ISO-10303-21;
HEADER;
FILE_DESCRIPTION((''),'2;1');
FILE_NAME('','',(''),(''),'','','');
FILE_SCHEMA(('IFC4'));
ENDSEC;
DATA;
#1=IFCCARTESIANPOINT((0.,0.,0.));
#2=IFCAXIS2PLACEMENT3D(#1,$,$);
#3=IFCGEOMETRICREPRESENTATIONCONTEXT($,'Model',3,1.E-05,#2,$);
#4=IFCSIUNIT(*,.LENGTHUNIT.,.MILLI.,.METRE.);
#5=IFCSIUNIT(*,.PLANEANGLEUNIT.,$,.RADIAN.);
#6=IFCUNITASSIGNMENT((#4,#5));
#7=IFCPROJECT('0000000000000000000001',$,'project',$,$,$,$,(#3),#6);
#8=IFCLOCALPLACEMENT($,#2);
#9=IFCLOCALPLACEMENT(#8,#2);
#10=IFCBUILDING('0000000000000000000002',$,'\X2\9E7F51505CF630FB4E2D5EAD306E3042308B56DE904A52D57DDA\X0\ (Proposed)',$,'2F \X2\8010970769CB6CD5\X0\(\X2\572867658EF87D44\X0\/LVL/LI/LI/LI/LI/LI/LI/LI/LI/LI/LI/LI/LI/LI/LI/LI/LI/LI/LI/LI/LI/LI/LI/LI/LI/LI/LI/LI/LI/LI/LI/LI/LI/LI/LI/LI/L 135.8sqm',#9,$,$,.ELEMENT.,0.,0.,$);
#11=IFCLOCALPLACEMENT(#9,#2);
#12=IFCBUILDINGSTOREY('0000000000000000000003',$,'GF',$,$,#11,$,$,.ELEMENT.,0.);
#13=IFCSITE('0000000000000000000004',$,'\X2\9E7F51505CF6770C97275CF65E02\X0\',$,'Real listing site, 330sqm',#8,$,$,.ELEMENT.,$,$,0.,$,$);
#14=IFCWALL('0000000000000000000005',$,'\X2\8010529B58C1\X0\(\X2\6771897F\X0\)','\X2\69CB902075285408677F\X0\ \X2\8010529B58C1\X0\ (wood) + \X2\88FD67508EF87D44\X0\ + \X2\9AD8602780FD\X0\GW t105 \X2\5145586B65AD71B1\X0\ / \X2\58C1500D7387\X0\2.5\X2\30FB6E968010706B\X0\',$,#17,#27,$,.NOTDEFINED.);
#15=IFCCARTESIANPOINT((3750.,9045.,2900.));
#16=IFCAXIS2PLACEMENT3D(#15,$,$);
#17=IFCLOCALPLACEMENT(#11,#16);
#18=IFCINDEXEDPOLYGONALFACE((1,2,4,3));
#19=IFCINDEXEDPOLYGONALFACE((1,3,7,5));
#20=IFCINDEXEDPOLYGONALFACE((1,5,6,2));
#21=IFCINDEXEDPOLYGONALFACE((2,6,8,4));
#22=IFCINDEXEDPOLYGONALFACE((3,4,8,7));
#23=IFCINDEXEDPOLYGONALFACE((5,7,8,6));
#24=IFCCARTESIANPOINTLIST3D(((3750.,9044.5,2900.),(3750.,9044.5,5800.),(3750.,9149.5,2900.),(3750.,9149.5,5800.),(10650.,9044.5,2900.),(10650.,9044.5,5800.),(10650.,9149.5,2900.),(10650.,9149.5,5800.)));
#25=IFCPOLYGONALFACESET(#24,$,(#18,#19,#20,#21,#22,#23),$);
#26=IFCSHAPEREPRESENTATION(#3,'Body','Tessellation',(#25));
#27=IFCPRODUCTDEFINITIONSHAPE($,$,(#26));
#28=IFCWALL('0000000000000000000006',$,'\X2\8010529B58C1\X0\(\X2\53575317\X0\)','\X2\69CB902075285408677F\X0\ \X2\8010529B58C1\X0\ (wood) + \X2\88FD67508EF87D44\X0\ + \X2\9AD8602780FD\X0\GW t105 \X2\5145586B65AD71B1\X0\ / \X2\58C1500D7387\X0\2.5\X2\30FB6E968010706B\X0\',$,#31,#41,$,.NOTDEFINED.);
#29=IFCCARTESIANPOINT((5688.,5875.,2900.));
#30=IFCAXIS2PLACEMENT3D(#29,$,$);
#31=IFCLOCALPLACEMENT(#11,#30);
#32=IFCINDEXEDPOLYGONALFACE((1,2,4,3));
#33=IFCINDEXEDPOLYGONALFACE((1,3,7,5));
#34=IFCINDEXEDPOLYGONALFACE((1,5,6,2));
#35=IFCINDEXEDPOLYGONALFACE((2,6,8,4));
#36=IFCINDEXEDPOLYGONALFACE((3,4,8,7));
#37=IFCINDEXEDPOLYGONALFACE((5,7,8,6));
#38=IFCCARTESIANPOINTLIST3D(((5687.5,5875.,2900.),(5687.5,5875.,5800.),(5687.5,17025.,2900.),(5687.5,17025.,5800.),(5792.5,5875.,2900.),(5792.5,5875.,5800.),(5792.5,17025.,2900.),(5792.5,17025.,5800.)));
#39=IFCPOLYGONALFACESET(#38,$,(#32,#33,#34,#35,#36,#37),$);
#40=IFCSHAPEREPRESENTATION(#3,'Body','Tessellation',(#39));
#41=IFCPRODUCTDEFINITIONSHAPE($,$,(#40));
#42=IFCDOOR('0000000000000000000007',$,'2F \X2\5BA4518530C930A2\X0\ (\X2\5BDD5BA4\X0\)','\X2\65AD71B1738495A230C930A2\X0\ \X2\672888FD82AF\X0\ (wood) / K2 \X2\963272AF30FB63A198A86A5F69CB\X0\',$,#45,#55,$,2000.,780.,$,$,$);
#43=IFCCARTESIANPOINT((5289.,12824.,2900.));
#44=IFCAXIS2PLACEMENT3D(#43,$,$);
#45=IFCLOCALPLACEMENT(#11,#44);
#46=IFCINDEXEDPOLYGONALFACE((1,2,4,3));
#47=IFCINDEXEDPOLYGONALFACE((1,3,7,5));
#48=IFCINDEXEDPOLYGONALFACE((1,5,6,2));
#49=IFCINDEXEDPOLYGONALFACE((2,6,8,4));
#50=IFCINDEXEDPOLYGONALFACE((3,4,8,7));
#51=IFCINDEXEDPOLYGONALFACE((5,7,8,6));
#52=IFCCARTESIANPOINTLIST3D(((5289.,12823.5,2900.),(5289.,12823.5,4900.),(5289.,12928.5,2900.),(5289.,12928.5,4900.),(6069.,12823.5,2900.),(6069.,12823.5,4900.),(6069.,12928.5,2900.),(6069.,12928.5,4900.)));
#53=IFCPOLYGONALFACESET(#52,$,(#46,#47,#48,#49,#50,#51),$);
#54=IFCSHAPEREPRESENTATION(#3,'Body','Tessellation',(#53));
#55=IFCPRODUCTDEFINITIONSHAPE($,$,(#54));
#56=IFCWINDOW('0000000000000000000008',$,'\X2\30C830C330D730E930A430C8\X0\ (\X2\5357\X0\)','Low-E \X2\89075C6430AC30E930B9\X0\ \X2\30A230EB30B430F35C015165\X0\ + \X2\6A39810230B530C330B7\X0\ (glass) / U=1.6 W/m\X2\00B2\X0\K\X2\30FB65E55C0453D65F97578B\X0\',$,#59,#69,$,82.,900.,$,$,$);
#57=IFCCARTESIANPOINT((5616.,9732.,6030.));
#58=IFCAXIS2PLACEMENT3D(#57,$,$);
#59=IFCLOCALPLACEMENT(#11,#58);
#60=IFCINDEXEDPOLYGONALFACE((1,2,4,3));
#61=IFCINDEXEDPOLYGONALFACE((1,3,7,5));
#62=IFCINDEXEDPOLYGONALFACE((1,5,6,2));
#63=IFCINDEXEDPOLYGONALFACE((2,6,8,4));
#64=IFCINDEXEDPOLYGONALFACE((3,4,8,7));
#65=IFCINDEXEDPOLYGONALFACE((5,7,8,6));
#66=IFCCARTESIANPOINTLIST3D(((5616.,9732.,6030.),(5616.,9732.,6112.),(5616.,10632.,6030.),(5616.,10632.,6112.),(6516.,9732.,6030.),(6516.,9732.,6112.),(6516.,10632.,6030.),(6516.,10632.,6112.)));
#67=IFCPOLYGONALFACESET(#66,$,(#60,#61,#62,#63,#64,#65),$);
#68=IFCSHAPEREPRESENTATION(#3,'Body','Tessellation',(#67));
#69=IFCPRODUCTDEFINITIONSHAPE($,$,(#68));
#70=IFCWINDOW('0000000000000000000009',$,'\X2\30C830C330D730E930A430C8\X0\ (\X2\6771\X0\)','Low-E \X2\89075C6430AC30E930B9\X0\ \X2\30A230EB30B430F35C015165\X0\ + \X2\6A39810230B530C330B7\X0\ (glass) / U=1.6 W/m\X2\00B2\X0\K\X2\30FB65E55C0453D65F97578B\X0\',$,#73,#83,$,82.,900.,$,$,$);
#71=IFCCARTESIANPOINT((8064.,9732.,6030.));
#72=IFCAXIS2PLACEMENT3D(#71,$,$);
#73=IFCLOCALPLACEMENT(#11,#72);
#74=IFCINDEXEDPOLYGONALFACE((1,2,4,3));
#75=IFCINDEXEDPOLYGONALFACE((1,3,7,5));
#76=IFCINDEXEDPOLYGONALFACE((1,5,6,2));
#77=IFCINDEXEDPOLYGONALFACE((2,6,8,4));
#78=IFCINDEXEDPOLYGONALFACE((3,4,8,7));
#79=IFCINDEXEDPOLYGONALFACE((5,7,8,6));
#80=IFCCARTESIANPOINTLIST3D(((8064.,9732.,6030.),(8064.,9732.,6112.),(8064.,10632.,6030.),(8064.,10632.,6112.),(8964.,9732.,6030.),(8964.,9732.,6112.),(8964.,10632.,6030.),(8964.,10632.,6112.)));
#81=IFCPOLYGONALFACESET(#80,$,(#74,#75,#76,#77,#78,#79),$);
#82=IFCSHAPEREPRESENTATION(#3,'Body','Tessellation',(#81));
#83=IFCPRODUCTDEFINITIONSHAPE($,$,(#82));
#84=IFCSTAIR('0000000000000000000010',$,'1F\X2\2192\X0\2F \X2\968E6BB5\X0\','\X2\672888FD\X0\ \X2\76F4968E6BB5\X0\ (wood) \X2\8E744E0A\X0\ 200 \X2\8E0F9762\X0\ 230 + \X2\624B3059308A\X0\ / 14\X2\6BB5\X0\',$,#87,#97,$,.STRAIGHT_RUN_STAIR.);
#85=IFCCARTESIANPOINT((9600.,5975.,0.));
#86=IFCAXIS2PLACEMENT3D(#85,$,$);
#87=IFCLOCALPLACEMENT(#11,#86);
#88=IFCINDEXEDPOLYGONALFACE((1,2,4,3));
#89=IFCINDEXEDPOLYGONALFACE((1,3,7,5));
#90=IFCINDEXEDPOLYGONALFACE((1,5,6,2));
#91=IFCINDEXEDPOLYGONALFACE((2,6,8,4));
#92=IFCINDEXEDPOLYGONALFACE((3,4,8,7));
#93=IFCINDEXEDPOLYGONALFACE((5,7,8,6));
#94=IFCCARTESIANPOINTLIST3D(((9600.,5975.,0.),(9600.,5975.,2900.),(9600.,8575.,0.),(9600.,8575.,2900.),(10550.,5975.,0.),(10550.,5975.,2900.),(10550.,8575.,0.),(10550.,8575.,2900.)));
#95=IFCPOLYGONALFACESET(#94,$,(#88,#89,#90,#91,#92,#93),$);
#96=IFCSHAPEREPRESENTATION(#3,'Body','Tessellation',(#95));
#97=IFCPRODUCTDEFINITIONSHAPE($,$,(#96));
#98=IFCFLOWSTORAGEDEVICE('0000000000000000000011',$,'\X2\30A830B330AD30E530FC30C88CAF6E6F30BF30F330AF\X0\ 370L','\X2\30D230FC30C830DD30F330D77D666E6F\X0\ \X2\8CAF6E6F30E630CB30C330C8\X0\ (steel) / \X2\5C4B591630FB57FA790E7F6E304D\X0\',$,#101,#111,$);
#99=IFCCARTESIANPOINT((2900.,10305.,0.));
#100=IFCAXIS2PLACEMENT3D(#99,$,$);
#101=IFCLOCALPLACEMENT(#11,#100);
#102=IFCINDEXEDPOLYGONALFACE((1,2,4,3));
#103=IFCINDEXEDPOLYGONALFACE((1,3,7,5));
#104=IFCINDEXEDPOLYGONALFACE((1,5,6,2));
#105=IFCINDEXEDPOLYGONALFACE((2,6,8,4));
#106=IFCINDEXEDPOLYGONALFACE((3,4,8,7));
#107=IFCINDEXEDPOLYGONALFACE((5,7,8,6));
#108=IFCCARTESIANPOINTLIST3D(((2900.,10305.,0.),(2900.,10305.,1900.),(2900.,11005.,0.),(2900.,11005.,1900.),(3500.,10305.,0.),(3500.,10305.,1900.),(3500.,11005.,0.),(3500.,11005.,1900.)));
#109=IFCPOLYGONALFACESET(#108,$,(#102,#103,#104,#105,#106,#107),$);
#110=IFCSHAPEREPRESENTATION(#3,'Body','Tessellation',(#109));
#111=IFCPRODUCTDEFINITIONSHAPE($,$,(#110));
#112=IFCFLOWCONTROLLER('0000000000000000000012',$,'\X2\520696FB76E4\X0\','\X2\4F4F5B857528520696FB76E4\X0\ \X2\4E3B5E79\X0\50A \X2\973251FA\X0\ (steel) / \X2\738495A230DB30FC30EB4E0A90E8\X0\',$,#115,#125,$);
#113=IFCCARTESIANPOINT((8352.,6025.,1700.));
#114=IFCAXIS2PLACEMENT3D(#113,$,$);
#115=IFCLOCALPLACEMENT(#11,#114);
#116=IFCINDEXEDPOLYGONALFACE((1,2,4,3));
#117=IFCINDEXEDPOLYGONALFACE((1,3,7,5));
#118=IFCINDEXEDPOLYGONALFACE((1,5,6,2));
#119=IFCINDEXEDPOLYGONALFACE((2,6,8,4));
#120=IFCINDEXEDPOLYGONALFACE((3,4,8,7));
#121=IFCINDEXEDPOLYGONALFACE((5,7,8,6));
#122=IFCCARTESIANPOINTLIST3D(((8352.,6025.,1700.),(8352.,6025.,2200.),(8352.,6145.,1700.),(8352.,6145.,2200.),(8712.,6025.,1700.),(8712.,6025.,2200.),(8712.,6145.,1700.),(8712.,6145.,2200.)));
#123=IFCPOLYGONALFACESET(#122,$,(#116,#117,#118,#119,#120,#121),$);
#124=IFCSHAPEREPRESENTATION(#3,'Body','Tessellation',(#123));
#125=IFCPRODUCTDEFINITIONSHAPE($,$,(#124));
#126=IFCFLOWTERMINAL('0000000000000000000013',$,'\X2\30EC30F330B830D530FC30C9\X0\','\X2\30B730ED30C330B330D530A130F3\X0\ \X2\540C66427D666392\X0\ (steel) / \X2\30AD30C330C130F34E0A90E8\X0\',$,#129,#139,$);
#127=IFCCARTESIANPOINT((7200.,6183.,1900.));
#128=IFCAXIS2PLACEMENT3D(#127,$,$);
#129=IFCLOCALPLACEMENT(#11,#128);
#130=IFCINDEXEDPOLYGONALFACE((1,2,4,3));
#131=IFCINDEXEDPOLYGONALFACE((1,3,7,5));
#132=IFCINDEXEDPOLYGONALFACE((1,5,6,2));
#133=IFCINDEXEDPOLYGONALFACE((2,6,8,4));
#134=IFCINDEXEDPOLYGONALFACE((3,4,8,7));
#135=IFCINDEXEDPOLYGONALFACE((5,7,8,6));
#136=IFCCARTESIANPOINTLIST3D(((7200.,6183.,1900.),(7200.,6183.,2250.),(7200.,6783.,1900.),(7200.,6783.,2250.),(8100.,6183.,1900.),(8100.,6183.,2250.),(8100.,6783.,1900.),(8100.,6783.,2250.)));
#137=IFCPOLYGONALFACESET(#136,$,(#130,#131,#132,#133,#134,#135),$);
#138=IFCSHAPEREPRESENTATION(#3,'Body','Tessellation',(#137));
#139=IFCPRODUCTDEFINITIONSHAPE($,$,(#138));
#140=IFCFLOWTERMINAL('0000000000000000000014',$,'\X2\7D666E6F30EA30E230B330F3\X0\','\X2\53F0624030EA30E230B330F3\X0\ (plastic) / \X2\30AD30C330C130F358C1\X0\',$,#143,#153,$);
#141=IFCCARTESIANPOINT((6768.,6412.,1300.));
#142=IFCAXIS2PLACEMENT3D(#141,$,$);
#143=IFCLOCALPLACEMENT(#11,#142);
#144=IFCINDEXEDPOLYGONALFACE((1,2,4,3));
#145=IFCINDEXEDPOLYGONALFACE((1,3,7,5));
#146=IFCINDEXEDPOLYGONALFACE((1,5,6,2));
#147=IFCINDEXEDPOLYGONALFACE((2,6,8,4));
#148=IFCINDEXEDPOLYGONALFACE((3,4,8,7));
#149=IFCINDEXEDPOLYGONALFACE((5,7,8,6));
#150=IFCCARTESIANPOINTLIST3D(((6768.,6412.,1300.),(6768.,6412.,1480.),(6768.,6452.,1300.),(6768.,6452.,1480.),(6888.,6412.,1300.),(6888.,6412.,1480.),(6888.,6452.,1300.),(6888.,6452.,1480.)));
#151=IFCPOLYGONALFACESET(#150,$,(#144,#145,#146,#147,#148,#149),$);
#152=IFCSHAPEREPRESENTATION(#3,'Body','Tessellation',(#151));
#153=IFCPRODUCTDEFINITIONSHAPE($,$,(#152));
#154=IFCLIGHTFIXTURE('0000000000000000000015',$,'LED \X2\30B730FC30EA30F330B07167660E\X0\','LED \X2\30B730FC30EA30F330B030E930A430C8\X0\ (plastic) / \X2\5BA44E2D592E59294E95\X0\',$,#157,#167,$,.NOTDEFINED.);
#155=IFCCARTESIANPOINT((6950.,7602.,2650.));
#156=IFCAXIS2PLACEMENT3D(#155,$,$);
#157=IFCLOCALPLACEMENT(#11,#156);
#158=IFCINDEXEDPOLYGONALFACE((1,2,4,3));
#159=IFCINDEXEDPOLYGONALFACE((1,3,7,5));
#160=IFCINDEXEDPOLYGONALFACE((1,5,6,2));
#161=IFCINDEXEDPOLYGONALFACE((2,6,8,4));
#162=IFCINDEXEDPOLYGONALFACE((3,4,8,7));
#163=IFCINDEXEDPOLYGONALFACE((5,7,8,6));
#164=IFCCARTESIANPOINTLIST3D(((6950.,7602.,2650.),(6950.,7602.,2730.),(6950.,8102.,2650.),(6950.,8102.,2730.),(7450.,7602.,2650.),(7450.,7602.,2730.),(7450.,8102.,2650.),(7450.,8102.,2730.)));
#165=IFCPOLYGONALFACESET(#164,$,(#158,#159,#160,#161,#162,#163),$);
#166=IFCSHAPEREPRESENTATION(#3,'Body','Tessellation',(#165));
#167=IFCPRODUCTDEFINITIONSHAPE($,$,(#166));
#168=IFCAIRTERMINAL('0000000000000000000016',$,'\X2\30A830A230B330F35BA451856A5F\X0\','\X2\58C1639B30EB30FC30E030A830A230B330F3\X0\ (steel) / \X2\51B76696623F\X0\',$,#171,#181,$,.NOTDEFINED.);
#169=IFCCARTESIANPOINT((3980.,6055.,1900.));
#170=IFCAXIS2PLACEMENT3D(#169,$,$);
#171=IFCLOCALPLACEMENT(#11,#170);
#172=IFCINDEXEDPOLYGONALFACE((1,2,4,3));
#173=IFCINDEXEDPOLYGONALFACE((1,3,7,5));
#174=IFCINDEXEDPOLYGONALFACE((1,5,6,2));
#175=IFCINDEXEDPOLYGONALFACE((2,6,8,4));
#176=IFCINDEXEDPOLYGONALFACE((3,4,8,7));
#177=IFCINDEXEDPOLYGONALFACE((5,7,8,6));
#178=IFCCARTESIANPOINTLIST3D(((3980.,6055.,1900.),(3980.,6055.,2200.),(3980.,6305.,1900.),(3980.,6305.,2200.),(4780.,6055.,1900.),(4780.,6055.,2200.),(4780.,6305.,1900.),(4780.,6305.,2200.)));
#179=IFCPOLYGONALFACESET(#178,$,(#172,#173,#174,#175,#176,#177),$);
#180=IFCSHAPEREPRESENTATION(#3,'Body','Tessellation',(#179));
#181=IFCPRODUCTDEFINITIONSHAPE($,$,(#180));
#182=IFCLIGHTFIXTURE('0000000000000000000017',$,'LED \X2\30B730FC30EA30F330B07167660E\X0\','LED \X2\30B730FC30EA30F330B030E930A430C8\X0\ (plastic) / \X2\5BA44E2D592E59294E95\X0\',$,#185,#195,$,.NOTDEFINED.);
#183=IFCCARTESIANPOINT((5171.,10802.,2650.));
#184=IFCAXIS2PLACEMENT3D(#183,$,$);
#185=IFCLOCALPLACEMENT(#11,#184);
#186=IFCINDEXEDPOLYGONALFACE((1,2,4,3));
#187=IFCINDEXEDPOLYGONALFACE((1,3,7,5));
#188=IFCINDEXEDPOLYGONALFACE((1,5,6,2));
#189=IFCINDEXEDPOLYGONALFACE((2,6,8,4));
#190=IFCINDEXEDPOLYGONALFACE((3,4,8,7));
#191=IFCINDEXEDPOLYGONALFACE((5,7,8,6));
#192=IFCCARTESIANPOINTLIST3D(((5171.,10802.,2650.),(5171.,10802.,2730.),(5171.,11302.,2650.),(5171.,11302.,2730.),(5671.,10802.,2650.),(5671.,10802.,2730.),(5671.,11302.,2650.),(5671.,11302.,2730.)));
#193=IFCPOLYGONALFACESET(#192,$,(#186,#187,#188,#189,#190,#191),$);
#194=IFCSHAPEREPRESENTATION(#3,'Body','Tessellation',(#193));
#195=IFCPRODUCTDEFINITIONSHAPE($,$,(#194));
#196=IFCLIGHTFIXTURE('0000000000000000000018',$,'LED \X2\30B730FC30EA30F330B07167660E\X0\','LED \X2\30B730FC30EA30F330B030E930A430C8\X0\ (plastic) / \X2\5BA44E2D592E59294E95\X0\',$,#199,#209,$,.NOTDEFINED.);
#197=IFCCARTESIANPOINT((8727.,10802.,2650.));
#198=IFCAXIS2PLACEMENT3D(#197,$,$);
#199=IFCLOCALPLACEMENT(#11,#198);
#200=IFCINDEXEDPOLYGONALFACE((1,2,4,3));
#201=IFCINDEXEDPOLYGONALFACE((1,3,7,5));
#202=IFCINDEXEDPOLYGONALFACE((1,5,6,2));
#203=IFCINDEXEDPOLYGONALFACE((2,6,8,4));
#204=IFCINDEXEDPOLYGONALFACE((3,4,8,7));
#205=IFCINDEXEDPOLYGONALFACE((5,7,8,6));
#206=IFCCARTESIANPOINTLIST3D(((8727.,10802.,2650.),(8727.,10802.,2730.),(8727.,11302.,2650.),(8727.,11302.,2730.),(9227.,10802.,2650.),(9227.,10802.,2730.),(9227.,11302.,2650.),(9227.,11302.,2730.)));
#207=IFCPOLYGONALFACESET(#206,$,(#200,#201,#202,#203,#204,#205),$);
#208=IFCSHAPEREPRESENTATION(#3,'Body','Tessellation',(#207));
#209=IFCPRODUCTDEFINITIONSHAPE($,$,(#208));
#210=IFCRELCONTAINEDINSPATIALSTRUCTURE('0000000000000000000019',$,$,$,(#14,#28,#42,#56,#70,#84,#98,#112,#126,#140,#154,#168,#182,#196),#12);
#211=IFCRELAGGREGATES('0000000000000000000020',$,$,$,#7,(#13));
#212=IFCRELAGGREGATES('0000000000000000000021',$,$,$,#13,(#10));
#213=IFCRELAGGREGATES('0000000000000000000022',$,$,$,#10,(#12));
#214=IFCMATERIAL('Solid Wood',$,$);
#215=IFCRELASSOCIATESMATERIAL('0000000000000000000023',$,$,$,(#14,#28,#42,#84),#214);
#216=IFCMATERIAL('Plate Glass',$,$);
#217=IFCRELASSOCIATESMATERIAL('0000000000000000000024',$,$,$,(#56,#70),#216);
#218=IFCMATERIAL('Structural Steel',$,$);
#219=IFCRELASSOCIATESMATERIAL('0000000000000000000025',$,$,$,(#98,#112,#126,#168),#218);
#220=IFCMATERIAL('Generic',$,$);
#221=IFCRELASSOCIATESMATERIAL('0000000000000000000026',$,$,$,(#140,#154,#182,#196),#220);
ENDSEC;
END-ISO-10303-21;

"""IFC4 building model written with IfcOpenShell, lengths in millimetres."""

from ifc_helpers import new_model, si_unit, frame, frame_2d, origin, place, context, project, spatial, rectangle, extrude, material, element, fill, save


model = new_model("IFC4")

# Units and contexts
model_context = context("Model", 3, precision=1e-05, world=origin())
ifc_project = project(units=[si_unit("LENGTHUNIT", "METRE", prefix="MILLI"), si_unit("PLANEANGLEUNIT", "RADIAN")], contexts=[model_context])

# Site, building, storey
site_placement = place(None, origin())
site = spatial("IfcSite", under=ifc_project, at=site_placement, Name="鹿児島県霧島市", ObjectType="Real listing site, 330sqm", CompositionType="ELEMENT", RefElevation=0.0)
building_placement = place(site_placement, origin())
building = spatial("IfcBuilding", under=site, at=building_placement, Name="鹿児島・中庭のある回遊動線 (Proposed)", ObjectType="2F 耐震構法(在来軸組/LVL/LI/LI/LI/LI/LI/LI/LI/LI/LI/LI/LI/LI/LI/LI/LI/LI/LI/LI/LI/LI/LI/LI/LI/LI/LI/LI/LI/LI/LI/LI/LI/LI/LI/LI/LI/L 135.8sqm", CompositionType="ELEMENT", ElevationOfRefHeight=0.0, ElevationOfTerrain=0.0)
storey_placement = place(building_placement, origin())
storey = spatial("IfcBuildingStorey", under=building, at=storey_placement, Name="GF", CompositionType="ELEMENT", Elevation=0.0)

# Shared definitions
ifc_material_1 = material(Name="Solid Wood")

# Wall
wall_1_placement = place(storey_placement, frame((3750.0, 9045.0, 2900.0)))
element("IfcWall", 1, at=wall_1_placement, inside=storey, material=ifc_material_1, Name="耐力壁(東西)", Description="構造用合板 耐力壁 (wood) + 製材軸組 + 高性能GW t105 充填断熱 / 壁倍率2.5・準耐火", PredefinedType="NOTDEFINED", context=model_context, shape_type="SweptSolid", body=[
    extrude(rectangle(XDim=6900.0, YDim=105.0, at=frame_2d((3450.0, 52.0))), frame((3750.0, 9045.0, 2900.0)), (0.0, 0.0, 1.0), 2900.0),
])

# Wall, opening, door
wall_2_placement = place(storey_placement, frame((5688.0, 5875.0, 2900.0)))
wall_2 = element("IfcWall", 2, at=wall_2_placement, inside=storey, material=ifc_material_1, Name="耐力壁(南北)", Description="構造用合板 耐力壁 (wood) + 製材軸組 + 高性能GW t105 充填断熱 / 壁倍率2.5・準耐火", PredefinedType="NOTDEFINED", context=model_context, shape_type="SweptSolid", body=[
    extrude(rectangle(XDim=105.0, YDim=11150.0, at=frame_2d((52.0, 5575.0))), frame((5688.0, 5875.0, 2900.0)), (0.0, 0.0, 1.0), 2900.0),
])
opening_placement = place(storey_placement, frame((5289.0, 12824.0, 2900.0)))
opening = element("IfcOpeningElement", 3, at=opening_placement, cuts=wall_2, PredefinedType="NOTDEFINED", context=model_context, shape_type="SweptSolid", body=[
    extrude(rectangle(XDim=780.0, YDim=105.0, at=frame_2d((390.0, 52.0))), frame((5289.0, 12824.0, 2900.0)), (0.0, 0.0, 1.0), 2000.0),
])
door_placement = place(storey_placement, frame((5289.0, 12824.0, 2900.0)))
door = element("IfcDoor", 4, at=door_placement, inside=storey, material=ifc_material_1, Name="2F 室内ドア (寝室)", Description="断熱玄関ドア 木製芯 (wood) / K2 防犯・採風機構", OverallHeight=2000.0, OverallWidth=780.0, context=model_context, shape_type="SweptSolid", body=[
    extrude(rectangle(XDim=780.0, YDim=105.0, at=frame_2d((390.0, 52.0))), frame((5289.0, 12824.0, 2900.0)), (0.0, 0.0, 1.0), 2000.0),
])
fill(opening, door)

# Windows
ifc_material_2 = material(Name="Plate Glass")
window_1_placement = place(storey_placement, frame((5616.0, 9732.0, 6030.0)))
element("IfcWindow", 5, at=window_1_placement, inside=storey, material=ifc_material_2, Name="トップライト (南)", Description="Low-E 複層ガラス アルゴン封入 + 樹脂サッシ (glass) / U=1.6 W/m²K・日射取得型", OverallHeight=82.0, OverallWidth=900.0, context=model_context, shape_type="SweptSolid", body=[
    extrude(rectangle(XDim=900.0, YDim=900.0, at=frame_2d((450.0, 450.0))), frame((5616.0, 9732.0, 6030.0)), (0.0, 0.0, 1.0), 82.0),
])
window_2_placement = place(storey_placement, frame((8064.0, 9732.0, 6030.0)))
element("IfcWindow", 6, at=window_2_placement, inside=storey, material=ifc_material_2, Name="トップライト (東)", Description="Low-E 複層ガラス アルゴン封入 + 樹脂サッシ (glass) / U=1.6 W/m²K・日射取得型", OverallHeight=82.0, OverallWidth=900.0, context=model_context, shape_type="SweptSolid", body=[
    extrude(rectangle(XDim=900.0, YDim=900.0, at=frame_2d((450.0, 450.0))), frame((8064.0, 9732.0, 6030.0)), (0.0, 0.0, 1.0), 82.0),
])

# Stair
stair_placement = place(storey_placement, frame((9600.0, 5975.0, 0.0)))
element("IfcStair", 7, at=stair_placement, inside=storey, material=ifc_material_1, Name="1F→2F 階段", Description="木製 直階段 (wood) 蹴上 200 踏面 230 + 手すり / 14段", PredefinedType="STRAIGHT_RUN_STAIR", context=model_context, shape_type="SweptSolid", body=[
    extrude(rectangle(XDim=950.0, YDim=2600.0, at=frame_2d((475.0, 1300.0))), frame((9600.0, 5975.0, 0.0)), (0.0, 0.0, 1.0), 2900.0),
])

# Flow storage device
ifc_material_3 = material(Name="Structural Steel")
flow_storage_device_placement = place(storey_placement, frame((2900.0, 10305.0, 0.0)))
element("IfcFlowStorageDevice", 8, at=flow_storage_device_placement, inside=storey, material=ifc_material_3, Name="エコキュート貯湯タンク 370L", Description="ヒートポンプ給湯 貯湯ユニット (steel) / 屋外・基礎置き", context=model_context, shape_type="SweptSolid", body=[
    extrude(rectangle(XDim=600.0, YDim=700.0, at=frame_2d((300.0, 350.0))), frame((2900.0, 10305.0, 0.0)), (0.0, 0.0, 1.0), 1900.0),
])

# Flow controller
flow_controller_placement = place(storey_placement, frame((8352.0, 6025.0, 1700.0)))
element("IfcFlowController", 9, at=flow_controller_placement, inside=storey, material=ifc_material_3, Name="分電盤", Description="住宅用分電盤 主幹50A 露出 (steel) / 玄関ホール上部", context=model_context, shape_type="SweptSolid", body=[
    extrude(rectangle(XDim=360.0, YDim=120.0, at=frame_2d((180.0, 60.0))), frame((8352.0, 6025.0, 1700.0)), (0.0, 0.0, 1.0), 500.0),
])

# Flow terminals
flow_terminal_1_placement = place(storey_placement, frame((7200.0, 6183.0, 1900.0)))
element("IfcFlowTerminal", 10, at=flow_terminal_1_placement, inside=storey, material=ifc_material_3, Name="レンジフード", Description="シロッコファン 同時給排 (steel) / キッチン上部", context=model_context, shape_type="SweptSolid", body=[
    extrude(rectangle(XDim=900.0, YDim=600.0, at=frame_2d((450.0, 300.0))), frame((7200.0, 6183.0, 1900.0)), (0.0, 0.0, 1.0), 350.0),
])
ifc_material_4 = material(Name="Generic")
flow_terminal_2_placement = place(storey_placement, frame((6768.0, 6412.0, 1300.0)))
element("IfcFlowTerminal", 11, at=flow_terminal_2_placement, inside=storey, material=ifc_material_4, Name="給湯リモコン", Description="台所リモコン (plastic) / キッチン壁", context=model_context, shape_type="SweptSolid", body=[
    extrude(rectangle(XDim=120.0, YDim=40.0, at=frame_2d((60.0, 20.0))), frame((6768.0, 6412.0, 1300.0)), (0.0, 0.0, 1.0), 180.0),
])

# Light fixture
light_fixture_1_placement = place(storey_placement, frame((6950.0, 7602.0, 2650.0)))
element("IfcLightFixture", 12, at=light_fixture_1_placement, inside=storey, material=ifc_material_4, Name="LED シーリング照明", Description="LED シーリングライト (plastic) / 室中央天井", PredefinedType="NOTDEFINED", context=model_context, shape_type="SweptSolid", body=[
    extrude(rectangle(XDim=500.0, YDim=500.0, at=frame_2d((250.0, 250.0))), frame((6950.0, 7602.0, 2650.0)), (0.0, 0.0, 1.0), 80.0),
])

# Air terminal
air_terminal_1_placement = place(storey_placement, frame((3980.0, 6055.0, 1900.0)))
element("IfcAirTerminal", 13, at=air_terminal_1_placement, inside=storey, material=ifc_material_3, Name="エアコン室内機", Description="壁掛ルームエアコン (steel) / 冷暖房", PredefinedType="NOTDEFINED", context=model_context, shape_type="SweptSolid", body=[
    extrude(rectangle(XDim=800.0, YDim=250.0, at=frame_2d((400.0, 125.0))), frame((3980.0, 6055.0, 1900.0)), (0.0, 0.0, 1.0), 300.0),
])

# Light fixtures
light_fixture_2_placement = place(storey_placement, frame((5171.0, 10802.0, 2650.0)))
element("IfcLightFixture", 14, at=light_fixture_2_placement, inside=storey, material=ifc_material_4, Name="LED シーリング照明", Description="LED シーリングライト (plastic) / 室中央天井", PredefinedType="NOTDEFINED", context=model_context, shape_type="SweptSolid", body=[
    extrude(rectangle(XDim=500.0, YDim=500.0, at=frame_2d((250.0, 250.0))), frame((5171.0, 10802.0, 2650.0)), (0.0, 0.0, 1.0), 80.0),
])
light_fixture_3_placement = place(storey_placement, frame((8727.0, 10802.0, 2650.0)))
element("IfcLightFixture", 15, at=light_fixture_3_placement, inside=storey, material=ifc_material_4, Name="LED シーリング照明", Description="LED シーリングライト (plastic) / 室中央天井", PredefinedType="NOTDEFINED", context=model_context, shape_type="SweptSolid", body=[
    extrude(rectangle(XDim=500.0, YDim=500.0, at=frame_2d((250.0, 250.0))), frame((8727.0, 10802.0, 2650.0)), (0.0, 0.0, 1.0), 80.0),
])

save(model, "model.ifc")
